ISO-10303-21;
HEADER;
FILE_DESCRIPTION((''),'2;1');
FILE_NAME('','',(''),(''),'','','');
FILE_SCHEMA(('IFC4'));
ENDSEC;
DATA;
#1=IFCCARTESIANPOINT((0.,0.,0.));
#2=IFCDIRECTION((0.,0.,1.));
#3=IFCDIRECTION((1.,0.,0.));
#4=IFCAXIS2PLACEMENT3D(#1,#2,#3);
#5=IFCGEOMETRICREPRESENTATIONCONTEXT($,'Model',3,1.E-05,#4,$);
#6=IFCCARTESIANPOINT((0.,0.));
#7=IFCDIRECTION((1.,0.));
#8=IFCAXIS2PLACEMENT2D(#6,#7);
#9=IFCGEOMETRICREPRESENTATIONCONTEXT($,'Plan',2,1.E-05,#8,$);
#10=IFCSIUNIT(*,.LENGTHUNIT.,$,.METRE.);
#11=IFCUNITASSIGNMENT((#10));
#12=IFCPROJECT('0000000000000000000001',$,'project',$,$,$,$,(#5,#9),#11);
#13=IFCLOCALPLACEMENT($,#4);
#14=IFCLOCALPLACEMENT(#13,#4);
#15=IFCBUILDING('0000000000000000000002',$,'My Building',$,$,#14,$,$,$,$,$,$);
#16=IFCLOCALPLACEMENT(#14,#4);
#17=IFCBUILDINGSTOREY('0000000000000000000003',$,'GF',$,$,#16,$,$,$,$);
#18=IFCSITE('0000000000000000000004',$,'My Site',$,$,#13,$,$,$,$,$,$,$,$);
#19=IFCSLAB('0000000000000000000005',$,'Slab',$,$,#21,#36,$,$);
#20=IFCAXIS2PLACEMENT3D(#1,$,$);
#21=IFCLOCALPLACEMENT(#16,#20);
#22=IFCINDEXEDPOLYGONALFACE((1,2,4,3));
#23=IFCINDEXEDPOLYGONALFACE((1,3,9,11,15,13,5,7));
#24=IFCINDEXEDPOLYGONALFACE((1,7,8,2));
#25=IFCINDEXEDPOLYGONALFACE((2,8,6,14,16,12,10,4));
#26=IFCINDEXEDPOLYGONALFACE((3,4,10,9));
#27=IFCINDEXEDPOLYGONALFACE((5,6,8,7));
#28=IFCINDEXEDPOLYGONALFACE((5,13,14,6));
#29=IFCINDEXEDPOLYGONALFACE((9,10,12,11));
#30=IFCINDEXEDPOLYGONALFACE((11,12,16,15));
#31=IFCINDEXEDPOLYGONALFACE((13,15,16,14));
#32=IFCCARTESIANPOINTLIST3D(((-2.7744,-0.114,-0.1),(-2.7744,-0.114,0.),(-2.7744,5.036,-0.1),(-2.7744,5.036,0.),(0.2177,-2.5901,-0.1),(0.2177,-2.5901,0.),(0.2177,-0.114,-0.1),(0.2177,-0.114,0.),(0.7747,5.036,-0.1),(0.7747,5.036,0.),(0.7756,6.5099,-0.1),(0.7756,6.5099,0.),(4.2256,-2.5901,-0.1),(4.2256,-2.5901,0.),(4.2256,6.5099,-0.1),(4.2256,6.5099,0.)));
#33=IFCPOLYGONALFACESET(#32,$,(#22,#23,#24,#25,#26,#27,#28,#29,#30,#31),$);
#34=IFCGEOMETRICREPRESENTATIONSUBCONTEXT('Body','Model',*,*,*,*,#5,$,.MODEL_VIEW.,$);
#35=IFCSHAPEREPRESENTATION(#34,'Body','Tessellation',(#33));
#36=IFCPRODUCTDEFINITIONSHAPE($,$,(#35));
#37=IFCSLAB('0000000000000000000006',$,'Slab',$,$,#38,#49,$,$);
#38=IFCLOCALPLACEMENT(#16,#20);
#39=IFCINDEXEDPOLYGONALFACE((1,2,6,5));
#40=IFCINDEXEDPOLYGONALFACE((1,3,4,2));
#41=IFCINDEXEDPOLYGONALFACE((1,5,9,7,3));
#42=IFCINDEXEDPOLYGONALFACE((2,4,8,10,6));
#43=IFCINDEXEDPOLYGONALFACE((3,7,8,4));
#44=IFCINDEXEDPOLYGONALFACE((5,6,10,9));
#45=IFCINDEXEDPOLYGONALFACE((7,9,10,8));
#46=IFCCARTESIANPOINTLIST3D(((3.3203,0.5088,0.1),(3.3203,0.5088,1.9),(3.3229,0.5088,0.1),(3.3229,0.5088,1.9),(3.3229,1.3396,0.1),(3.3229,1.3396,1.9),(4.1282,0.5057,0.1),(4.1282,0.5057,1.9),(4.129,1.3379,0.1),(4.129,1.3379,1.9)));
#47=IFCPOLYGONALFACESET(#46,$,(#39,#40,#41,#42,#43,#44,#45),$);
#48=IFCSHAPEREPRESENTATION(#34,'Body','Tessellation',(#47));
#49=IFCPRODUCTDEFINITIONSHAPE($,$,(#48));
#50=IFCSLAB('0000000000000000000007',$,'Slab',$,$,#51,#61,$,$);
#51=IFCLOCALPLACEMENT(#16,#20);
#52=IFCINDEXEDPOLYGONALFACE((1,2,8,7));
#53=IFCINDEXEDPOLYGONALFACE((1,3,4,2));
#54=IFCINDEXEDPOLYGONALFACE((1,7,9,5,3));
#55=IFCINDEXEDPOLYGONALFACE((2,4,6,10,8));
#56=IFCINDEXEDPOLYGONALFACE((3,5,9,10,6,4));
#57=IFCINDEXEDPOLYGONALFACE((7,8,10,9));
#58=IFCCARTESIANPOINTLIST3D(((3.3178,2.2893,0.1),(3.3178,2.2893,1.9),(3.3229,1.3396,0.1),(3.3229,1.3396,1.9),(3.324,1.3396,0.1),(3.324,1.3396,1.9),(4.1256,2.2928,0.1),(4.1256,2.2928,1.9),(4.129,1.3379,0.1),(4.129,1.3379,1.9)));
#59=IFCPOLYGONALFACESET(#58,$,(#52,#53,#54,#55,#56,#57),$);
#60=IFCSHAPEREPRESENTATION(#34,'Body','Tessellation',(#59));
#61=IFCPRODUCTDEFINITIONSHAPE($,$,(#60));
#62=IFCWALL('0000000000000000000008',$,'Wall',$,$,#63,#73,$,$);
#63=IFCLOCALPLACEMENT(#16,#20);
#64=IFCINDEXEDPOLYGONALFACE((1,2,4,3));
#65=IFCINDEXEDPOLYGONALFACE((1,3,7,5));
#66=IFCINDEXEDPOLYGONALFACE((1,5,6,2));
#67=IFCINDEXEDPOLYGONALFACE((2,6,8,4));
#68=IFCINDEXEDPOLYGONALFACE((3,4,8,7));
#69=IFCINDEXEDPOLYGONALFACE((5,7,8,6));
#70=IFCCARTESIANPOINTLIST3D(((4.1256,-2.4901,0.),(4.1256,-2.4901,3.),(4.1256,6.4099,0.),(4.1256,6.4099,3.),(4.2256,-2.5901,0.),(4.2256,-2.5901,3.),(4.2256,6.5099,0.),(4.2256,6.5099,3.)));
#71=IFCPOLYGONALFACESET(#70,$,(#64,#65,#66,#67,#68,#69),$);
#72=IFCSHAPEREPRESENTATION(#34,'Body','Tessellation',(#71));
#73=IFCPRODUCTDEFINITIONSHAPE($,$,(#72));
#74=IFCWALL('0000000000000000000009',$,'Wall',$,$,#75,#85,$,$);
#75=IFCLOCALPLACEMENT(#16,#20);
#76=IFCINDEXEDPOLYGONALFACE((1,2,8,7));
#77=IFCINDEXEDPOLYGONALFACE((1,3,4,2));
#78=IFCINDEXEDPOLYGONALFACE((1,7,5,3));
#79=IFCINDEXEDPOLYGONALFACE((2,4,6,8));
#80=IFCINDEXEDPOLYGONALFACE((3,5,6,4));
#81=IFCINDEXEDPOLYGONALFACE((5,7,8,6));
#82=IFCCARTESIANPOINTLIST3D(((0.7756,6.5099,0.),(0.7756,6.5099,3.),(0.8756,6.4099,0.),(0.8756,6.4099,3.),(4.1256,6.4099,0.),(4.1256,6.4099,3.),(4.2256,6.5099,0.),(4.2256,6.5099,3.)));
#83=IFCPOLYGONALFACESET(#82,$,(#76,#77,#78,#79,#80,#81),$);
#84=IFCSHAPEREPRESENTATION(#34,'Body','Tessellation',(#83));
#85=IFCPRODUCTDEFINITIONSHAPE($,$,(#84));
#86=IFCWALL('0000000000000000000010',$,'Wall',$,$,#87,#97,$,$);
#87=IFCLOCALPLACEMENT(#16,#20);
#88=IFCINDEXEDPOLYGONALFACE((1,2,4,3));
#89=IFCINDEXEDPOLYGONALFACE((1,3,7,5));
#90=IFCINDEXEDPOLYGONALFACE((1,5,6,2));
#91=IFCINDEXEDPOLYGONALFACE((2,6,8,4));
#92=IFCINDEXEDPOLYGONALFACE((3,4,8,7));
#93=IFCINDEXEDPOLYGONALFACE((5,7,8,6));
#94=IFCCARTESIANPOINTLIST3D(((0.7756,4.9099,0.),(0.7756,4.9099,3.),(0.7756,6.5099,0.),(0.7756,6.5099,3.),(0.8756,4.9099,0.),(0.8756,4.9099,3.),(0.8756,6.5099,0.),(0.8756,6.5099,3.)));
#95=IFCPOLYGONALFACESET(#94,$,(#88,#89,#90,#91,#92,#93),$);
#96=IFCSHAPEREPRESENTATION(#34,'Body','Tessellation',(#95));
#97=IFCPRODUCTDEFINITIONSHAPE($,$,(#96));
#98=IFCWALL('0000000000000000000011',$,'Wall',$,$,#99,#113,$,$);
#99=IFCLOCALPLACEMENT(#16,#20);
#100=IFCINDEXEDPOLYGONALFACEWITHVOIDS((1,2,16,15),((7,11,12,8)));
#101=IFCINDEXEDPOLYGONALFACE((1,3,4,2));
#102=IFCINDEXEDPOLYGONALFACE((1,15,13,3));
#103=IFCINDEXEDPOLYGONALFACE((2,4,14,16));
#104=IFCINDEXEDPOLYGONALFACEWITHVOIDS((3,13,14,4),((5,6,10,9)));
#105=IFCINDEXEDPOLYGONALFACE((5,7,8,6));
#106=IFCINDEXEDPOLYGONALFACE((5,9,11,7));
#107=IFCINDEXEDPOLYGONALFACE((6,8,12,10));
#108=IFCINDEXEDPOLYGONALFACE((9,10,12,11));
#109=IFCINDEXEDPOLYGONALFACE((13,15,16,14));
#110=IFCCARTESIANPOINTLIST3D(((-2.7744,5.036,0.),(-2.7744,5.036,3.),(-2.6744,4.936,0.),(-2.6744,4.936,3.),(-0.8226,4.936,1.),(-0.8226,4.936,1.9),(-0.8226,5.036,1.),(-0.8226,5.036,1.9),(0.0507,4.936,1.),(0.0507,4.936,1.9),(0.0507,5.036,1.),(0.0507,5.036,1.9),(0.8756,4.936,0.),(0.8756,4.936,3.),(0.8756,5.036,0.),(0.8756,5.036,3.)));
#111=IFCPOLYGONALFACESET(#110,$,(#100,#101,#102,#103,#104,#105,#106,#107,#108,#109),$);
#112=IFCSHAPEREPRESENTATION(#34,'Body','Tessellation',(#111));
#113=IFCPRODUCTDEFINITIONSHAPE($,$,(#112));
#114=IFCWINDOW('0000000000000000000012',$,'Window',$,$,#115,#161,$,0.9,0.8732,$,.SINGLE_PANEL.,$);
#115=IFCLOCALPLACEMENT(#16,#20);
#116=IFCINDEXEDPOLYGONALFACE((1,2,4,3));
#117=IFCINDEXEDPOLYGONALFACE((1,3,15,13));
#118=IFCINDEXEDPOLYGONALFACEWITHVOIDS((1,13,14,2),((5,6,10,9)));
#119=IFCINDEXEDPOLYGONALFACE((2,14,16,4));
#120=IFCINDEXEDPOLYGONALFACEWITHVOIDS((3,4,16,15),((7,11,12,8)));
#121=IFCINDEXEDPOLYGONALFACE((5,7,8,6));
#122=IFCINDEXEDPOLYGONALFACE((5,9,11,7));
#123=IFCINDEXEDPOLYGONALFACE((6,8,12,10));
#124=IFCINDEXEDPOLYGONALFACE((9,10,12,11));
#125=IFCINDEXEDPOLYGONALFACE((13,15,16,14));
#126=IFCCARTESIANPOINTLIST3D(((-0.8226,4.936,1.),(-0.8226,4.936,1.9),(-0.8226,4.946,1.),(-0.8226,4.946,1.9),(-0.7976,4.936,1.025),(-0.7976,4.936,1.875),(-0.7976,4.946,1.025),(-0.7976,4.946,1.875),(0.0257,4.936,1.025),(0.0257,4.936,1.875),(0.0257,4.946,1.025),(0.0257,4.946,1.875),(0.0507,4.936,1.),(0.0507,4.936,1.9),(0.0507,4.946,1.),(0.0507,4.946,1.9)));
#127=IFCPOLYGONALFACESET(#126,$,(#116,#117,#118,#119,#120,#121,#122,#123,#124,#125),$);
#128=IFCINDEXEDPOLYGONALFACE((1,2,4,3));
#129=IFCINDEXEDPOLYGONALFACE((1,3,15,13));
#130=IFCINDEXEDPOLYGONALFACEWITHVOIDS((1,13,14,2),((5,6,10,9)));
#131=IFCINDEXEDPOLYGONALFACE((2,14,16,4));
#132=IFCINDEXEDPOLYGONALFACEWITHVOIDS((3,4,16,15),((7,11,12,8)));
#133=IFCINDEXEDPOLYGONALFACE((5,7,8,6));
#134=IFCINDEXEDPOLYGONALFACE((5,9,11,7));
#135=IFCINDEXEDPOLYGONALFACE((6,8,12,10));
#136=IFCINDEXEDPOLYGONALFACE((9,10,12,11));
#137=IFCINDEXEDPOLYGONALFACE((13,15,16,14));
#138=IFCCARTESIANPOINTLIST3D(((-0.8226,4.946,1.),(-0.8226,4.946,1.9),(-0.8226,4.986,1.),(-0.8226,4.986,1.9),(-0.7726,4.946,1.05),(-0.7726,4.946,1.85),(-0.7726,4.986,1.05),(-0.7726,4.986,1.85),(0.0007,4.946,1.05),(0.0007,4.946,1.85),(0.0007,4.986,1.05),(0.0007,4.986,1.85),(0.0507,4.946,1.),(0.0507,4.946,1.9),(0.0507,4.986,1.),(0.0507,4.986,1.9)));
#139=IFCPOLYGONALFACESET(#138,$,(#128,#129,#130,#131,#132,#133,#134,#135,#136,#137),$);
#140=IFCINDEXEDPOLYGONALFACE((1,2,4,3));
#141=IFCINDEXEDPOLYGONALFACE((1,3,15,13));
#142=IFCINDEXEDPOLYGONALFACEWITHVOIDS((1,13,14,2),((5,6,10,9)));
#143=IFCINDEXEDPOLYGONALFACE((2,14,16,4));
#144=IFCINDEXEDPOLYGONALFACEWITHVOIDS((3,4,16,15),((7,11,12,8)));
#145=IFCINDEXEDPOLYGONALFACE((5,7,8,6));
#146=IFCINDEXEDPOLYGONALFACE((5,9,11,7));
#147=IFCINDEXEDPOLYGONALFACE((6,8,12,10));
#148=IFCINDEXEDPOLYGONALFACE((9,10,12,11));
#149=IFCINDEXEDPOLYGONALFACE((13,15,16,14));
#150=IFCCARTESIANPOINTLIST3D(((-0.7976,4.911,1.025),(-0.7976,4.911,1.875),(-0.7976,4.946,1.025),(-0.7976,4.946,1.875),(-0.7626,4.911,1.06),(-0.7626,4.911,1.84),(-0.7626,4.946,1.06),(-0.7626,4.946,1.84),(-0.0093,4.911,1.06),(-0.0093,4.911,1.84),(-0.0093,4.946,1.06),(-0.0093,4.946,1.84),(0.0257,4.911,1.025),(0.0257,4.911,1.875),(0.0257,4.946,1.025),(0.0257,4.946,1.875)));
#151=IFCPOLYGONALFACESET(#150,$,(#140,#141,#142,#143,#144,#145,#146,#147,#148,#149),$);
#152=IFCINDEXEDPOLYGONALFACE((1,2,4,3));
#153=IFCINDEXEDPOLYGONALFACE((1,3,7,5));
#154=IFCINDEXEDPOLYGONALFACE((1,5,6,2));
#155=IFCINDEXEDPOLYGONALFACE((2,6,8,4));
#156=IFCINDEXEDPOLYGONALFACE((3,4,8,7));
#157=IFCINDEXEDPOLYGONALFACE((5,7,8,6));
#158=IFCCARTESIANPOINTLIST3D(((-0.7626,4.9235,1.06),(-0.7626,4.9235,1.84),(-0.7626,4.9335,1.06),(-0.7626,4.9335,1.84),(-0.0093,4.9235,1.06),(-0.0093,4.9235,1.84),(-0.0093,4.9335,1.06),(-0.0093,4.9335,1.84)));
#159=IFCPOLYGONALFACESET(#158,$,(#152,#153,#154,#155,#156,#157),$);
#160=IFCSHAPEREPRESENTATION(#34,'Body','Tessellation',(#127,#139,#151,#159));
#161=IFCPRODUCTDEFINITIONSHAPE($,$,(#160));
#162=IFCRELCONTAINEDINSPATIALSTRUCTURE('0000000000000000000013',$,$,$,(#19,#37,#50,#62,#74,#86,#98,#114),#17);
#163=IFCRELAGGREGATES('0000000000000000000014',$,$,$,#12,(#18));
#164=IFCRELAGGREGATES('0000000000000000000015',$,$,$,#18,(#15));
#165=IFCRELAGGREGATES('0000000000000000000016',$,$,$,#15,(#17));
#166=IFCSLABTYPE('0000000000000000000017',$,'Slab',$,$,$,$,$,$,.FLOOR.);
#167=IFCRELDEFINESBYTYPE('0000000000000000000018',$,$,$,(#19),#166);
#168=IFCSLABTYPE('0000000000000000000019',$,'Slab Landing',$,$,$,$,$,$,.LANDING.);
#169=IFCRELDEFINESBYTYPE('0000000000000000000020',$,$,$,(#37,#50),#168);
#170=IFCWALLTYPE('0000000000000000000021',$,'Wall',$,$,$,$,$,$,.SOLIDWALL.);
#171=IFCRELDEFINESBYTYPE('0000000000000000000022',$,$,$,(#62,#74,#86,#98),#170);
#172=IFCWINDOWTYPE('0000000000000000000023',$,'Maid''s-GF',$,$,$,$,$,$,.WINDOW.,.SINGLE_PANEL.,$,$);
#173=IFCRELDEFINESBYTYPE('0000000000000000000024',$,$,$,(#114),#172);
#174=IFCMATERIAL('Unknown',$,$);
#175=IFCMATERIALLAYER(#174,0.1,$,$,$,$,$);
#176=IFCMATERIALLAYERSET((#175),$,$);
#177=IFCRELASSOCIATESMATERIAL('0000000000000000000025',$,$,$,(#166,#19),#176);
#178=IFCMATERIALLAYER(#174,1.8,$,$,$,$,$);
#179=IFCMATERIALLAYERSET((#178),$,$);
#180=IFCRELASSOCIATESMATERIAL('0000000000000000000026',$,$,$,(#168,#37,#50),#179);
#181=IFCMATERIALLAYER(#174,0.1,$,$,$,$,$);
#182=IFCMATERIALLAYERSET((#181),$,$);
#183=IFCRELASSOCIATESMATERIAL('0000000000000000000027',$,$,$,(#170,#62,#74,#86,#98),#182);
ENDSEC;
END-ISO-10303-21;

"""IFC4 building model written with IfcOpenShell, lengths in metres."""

from ifc_helpers import new_model, entity, si_unit, frame, origin_with_axes, origin_2d_with_axis, place, context, subcontext, project, spatial, line, indexed_curve, outline, extrude, shape, source, transform, mapped, material, layer, layer_set, layer_usage, type_object, type_shapes, element, fill, save


model = new_model("IFC4")

# Units and contexts
model_context = context("Model", 3, precision=1e-05, world=origin_with_axes())
plan_context = context("Plan", 2, precision=1e-05, world=origin_2d_with_axis())
body_context_1 = subcontext(model_context, "Body", "Model", "MODEL_VIEW")
body_context_2 = subcontext(plan_context, "Body", "Plan", "PLAN_VIEW")
ifc_project = project(units=[si_unit("LENGTHUNIT", "METRE")], contexts=[model_context, plan_context])

# Site, building, storey
site_placement = place(None, origin_with_axes())
site = spatial("IfcSite", under=ifc_project, at=site_placement, Name="My Site")
building_placement = place(site_placement, origin_with_axes())
building = spatial("IfcBuilding", under=site, at=building_placement, Name="My Building")
storey_placement = place(building_placement, origin_with_axes())
storey = spatial("IfcBuildingStorey", under=building, at=storey_placement, Name="GF")

# Slabs
ifc_material_1 = material(Name="Unknown")
ifc_layer_1 = layer(ifc_material_1, 0.1)
ifc_layer_set_1 = layer_set([ifc_layer_1])
ifc_layer_usage_1 = layer_usage(ifc_layer_set_1, "AXIS3", "POSITIVE", -0.1)
slab_type_1 = type_object("IfcSlabType", Name="Slab", PredefinedType="FLOOR", material=ifc_layer_set_1)
slab_1_placement = place(storey_placement, frame((4.2256, -2.5901, 0.0), z_axis=(0.0, 0.0, 1.0), x_axis=(1.0, 0.0, 0.0)))
element("IfcSlab", 1, at=slab_1_placement, inside=storey, type_object=slab_type_1, material=ifc_layer_usage_1, Name="Slab", context=body_context_1, shape_type="SweptSolid", body=[
    extrude(outline(indexed_curve([(0.0, 0.0), (0.0, 9.1), (-3.45, 9.1), (-3.4508, 7.6261), (-7.0, 7.6261), (-7.0, 2.4761), (-4.0079, 2.4761), (-4.0079, 0.0), (0.0, 0.0)])), frame((0.0, 0.0, -0.1), z_axis=(0.0, 0.0, 1.0), x_axis=(1.0, 0.0, 0.0)), (0.0, 0.0, 1.0), 0.1),
])
ifc_layer_2 = layer(ifc_material_1, 1.8)
ifc_layer_set_2 = layer_set([ifc_layer_2])
ifc_layer_usage_2 = layer_usage(ifc_layer_set_2, "AXIS3", "POSITIVE", -0.1)
slab_type_2 = type_object("IfcSlabType", Name="Slab Landing", PredefinedType="LANDING", material=ifc_layer_set_2)
slab_2_placement = place(storey_placement, frame((3.3229, 0.5088, 0.2), z_axis=(0.0, 0.0, 1.0), x_axis=(1.0, 0.0, 0.0)))
element("IfcSlab", 2, at=slab_2_placement, inside=storey, type_object=slab_type_2, material=ifc_layer_usage_2, Name="Slab", context=body_context_1, shape_type="SweptSolid", body=[
    extrude(outline(indexed_curve([(-0.0026, 0.0), (0.0, 0.8308), (0.806, 0.8291), (0.8053, -0.0031), (0.0, 0.0), (-0.0026, 0.0)])), frame((0.0, 0.0, -0.1), z_axis=(0.0, 0.0, 1.0), x_axis=(1.0, 0.0, 0.0)), (0.0, 0.0, 1.0), 1.8),
])
ifc_layer_usage_3 = layer_usage(ifc_layer_set_2, "AXIS3", "POSITIVE", -1.8)
slab_3_placement = place(storey_placement, frame((3.324, 1.3396, 1.9), z_axis=(0.0, 0.0, 1.0), x_axis=(1.0, 0.0, 0.0)))
element("IfcSlab", 3, at=slab_3_placement, inside=storey, type_object=slab_type_2, material=ifc_layer_usage_3, Name="Slab", context=body_context_1, shape_type="SweptSolid", body=[
    extrude(outline(indexed_curve([(-0.001, 0.0), (-0.0061, 0.9497), (0.8016, 0.9532), (0.805, -0.0017), (0.0, 0.0), (-0.001, 0.0)])), frame((0.0, 0.0, -1.8), z_axis=(0.0, 0.0, 1.0), x_axis=(1.0, 0.0, 0.0)), (0.0, 0.0, 1.0), 1.8),
])

# Shared definitions
ifc_layer_3 = layer(ifc_material_1, 0.1)
ifc_layer_set_3 = layer_set([ifc_layer_3])
wall_type = type_object("IfcWallType", Name="Wall", PredefinedType="SOLIDWALL", material=ifc_layer_set_3)

# Walls
ifc_layer_usage_4 = layer_usage(ifc_layer_set_3, "AXIS2", "POSITIVE", 0.0)
wall_1_placement = place(storey_placement, frame((4.2256, -2.5901, 0.0), z_axis=(0.0, 0.0, 1.0), x_axis=(0.0, 1.0, 0.0)))
element("IfcWall", 4, at=wall_1_placement, inside=storey, type_object=wall_type, material=ifc_layer_usage_4, Name="Wall", context=body_context_1, shape_type="SweptSolid", body=[
    extrude(outline(indexed_curve([(0.0, 0.0), (0.1, 0.1), (9.0, 0.1), (9.1, 0.0)], segments=[line(1, 2, 3, 4, 1)])), origin_with_axes(), (0.0, 0.0, 1.0), 3.0),
])
ifc_layer_usage_5 = layer_usage(ifc_layer_set_3, "AXIS2", "POSITIVE", 0.0)
wall_2_placement = place(storey_placement, frame((4.2256, 6.5099, 0.0), z_axis=(0.0, 0.0, 1.0), x_axis=(-1.0, 0.0, 0.0)))
element("IfcWall", 5, at=wall_2_placement, inside=storey, type_object=wall_type, material=ifc_layer_usage_5, Name="Wall", context=body_context_1, shape_type="SweptSolid", body=[
    extrude(outline(indexed_curve([(0.0, 0.0), (0.1, 0.1), (3.35, 0.1), (3.45, 0.0)], segments=[line(1, 2, 3, 4, 1)])), origin_with_axes(), (0.0, 0.0, 1.0), 3.0),
])
ifc_layer_usage_6 = layer_usage(ifc_layer_set_3, "AXIS2", "POSITIVE", 0.0)
wall_3_placement = place(storey_placement, frame((0.7756, 6.5099, 0.0), z_axis=(0.0, 0.0, 1.0), x_axis=(0.0, -1.0, 0.0)))
element("IfcWall", 6, at=wall_3_placement, inside=storey, type_object=wall_type, material=ifc_layer_usage_6, Name="Wall", context=body_context_1, shape_type="SweptSolid", body=[
    extrude(outline(indexed_curve([(0.0, 0.0), (0.0, 0.1), (1.6, 0.1), (1.6, 0.0)], segments=[line(1, 2, 3, 4, 1)])), origin_with_axes(), (0.0, 0.0, 1.0), 3.0),
])

# Wall, opening, window
ifc_layer_usage_7 = layer_usage(ifc_layer_set_3, "AXIS2", "POSITIVE", 0.0)
wall_4_placement = place(storey_placement, frame((0.8756, 5.036, 0.0), z_axis=(0.0, 0.0, 1.0), x_axis=(-1.0, 0.0, 0.0)))
wall_4 = element("IfcWall", 7, at=wall_4_placement, inside=storey, type_object=wall_type, material=ifc_layer_usage_7, Name="Wall", context=body_context_1, shape_type="SweptSolid", body=[
    extrude(outline(indexed_curve([(0.0, 0.0), (0.0, 0.1), (3.55, 0.1), (3.65, 0.0)], segments=[line(1, 2, 3, 4, 1)])), origin_with_axes(), (0.0, 0.0, 1.0), 3.0),
])
shared_shape_1 = source(origin_with_axes(), body_context_1, "Body", "SweptSolid", [
    extrude(outline(indexed_curve([(0.0, 0.0), (0.8732, 0.0), (0.8732, 0.9), (0.0, 0.9)], segments=[line(1, 2, 3, 4, 1)])), frame((0.0, -0.6, 0.0), z_axis=(0.0, -1.0, 0.0), x_axis=(1.0, 0.0, 0.0)), (0.0, 0.0, -1.0), 1.2),
])
opening_1_placement = place(wall_4_placement, frame((0.8249, 0.0, 1.0), z_axis=(0.0, 0.0, 1.0), x_axis=(1.0, 0.0, 0.0)))
opening_1 = element("IfcOpeningElement", 8, at=opening_1_placement, cuts=wall_4, PredefinedType="OPENING", context=body_context_1, shape_type="MappedRepresentation", body=[
    mapped(shared_shape_1, transform((0.0, 0.0, 0.0), x_axis=(1.0, 0.0, 0.0), y_axis=(0.0, 1.0, 0.0), z_axis=(0.0, 0.0, 1.0), scale=1.0)),
])
window_type_1 = type_object("IfcWindowType", Name="Maid's-GF", PartitioningType="SINGLE_PANEL", PredefinedType="WINDOW")
shared_shape_2 = source(origin_with_axes(), body_context_1, "Body", "SweptSolid", [
    extrude(outline(indexed_curve([(0.0, 0.0), (0.8732, 0.0), (0.8732, 0.9), (0.0, 0.9)], segments=[line(1, 2, 3, 4, 1)]), holes=[indexed_curve([(0.025, 0.025), (0.8482, 0.025), (0.8482, 0.875), (0.025, 0.875)], segments=[line(1, 2, 3, 4, 1)])]), frame((0.0, 0.09, 0.0), z_axis=(0.0, -1.0, 0.0), x_axis=(1.0, 0.0, 0.0)), (0.0, 0.0, -1.0), 0.01),
    extrude(outline(indexed_curve([(0.0, 0.0), (0.8732, 0.0), (0.8732, 0.9), (0.0, 0.9)], segments=[line(1, 2, 3, 4, 1)]), holes=[indexed_curve([(0.05, 0.05), (0.8232, 0.05), (0.8232, 0.85), (0.05, 0.85)], segments=[line(1, 2, 3, 4, 1)])]), frame((0.0, 0.05, 0.0), z_axis=(0.0, -1.0, 0.0), x_axis=(1.0, 0.0, 0.0)), (0.0, 0.0, -1.0), 0.04),
    extrude(outline(indexed_curve([(0.0, 0.0), (0.8232, 0.0), (0.8232, 0.85), (0.0, 0.85)], segments=[line(1, 2, 3, 4, 1)]), holes=[indexed_curve([(0.035, 0.035), (0.7882, 0.035), (0.7882, 0.815), (0.035, 0.815)], segments=[line(1, 2, 3, 4, 1)])]), frame((0.025, 0.09, 0.025), z_axis=(0.0, -1.0, 0.0), x_axis=(1.0, 0.0, 0.0)), (0.0, 0.0, -1.0), 0.035),
    extrude(outline(indexed_curve([(0.035, 0.035), (0.7882, 0.035), (0.7882, 0.815), (0.035, 0.815)], segments=[line(1, 2, 3, 4, 1)])), frame((0.025, 0.1025, 0.025), z_axis=(0.0, -1.0, 0.0), x_axis=(1.0, 0.0, 0.0)), (0.0, 0.0, -1.0), 0.01),
])
shared_shape_3 = source(origin_with_axes(), body_context_2, "Body", "Curve2D", [
    entity("IfcIndexedPolyCurve", entity("IfcCartesianPointList2D", [[0.05, 0.05], [0.8232, 0.05]])),
    entity("IfcIndexedPolyCurve", entity("IfcCartesianPointList2D", [[0.0, 0.1], [0.025, 0.1], [0.025, 0.09], [0.05, 0.09], [0.05, 0.05], [0.0, 0.05]]), [entity("IfcLineIndex", [1, 2, 3, 4, 5, 6, 1])]),
    entity("IfcIndexedPolyCurve", entity("IfcCartesianPointList2D", [[0.8732, 0.1], [0.8482, 0.1], [0.8482, 0.09], [0.8232, 0.09], [0.8232, 0.05], [0.8732, 0.05]]), [entity("IfcLineIndex", [1, 2, 3, 4, 5, 6, 1])]),
    entity("IfcIndexedPolyCurve", entity("IfcCartesianPointList2D", [[0.025, 0.09], [0.06, 0.09], [0.06, 0.125], [0.025, 0.125]]), [entity("IfcLineIndex", [1, 2, 3, 4, 1])]),
    entity("IfcIndexedPolyCurve", entity("IfcCartesianPointList2D", [[0.8482, 0.09], [0.8132, 0.09], [0.8132, 0.125], [0.8482, 0.125]]), [entity("IfcLineIndex", [1, 2, 3, 4, 1])]),
    entity("IfcIndexedPolyCurve", entity("IfcCartesianPointList2D", [[0.06, 0.09], [0.8132, 0.09]])),
    entity("IfcIndexedPolyCurve", entity("IfcCartesianPointList2D", [[0.06, 0.125], [0.8132, 0.125]])),
    entity("IfcIndexedPolyCurve", entity("IfcCartesianPointList2D", [[0.06, 0.1075], [0.8132, 0.1075]])),
])
type_shapes(window_type_1, [shared_shape_2, shared_shape_3])
window_1_placement = place(opening_1_placement, frame((0.0, 0.0, 0.0), z_axis=(0.0, 0.0, 1.0), x_axis=(1.0, 0.0, 0.0)))
window_1 = element("IfcWindow", 9, at=window_1_placement, inside=storey, type_object=window_type_1, Name="Window", OverallHeight=0.9, OverallWidth=0.8732, PartitioningType="SINGLE_PANEL", shapes=[
    shape(body_context_1, "Body", "MappedRepresentation", [mapped(shared_shape_2, transform((0.0, 0.0, 0.0), x_axis=(1.0, 0.0, 0.0), y_axis=(0.0, 1.0, 0.0), z_axis=(0.0, 0.0, 1.0), scale=1.0))]),
    shape(body_context_2, "Body", "MappedRepresentation", [mapped(shared_shape_3, transform((0.0, 0.0, 0.0), x_axis=(1.0, 0.0, 0.0), y_axis=(0.0, 1.0, 0.0), z_axis=(0.0, 0.0, 1.0), scale=1.0))]),
])
fill(opening_1, window_1)

save(model, "model.ifc")
